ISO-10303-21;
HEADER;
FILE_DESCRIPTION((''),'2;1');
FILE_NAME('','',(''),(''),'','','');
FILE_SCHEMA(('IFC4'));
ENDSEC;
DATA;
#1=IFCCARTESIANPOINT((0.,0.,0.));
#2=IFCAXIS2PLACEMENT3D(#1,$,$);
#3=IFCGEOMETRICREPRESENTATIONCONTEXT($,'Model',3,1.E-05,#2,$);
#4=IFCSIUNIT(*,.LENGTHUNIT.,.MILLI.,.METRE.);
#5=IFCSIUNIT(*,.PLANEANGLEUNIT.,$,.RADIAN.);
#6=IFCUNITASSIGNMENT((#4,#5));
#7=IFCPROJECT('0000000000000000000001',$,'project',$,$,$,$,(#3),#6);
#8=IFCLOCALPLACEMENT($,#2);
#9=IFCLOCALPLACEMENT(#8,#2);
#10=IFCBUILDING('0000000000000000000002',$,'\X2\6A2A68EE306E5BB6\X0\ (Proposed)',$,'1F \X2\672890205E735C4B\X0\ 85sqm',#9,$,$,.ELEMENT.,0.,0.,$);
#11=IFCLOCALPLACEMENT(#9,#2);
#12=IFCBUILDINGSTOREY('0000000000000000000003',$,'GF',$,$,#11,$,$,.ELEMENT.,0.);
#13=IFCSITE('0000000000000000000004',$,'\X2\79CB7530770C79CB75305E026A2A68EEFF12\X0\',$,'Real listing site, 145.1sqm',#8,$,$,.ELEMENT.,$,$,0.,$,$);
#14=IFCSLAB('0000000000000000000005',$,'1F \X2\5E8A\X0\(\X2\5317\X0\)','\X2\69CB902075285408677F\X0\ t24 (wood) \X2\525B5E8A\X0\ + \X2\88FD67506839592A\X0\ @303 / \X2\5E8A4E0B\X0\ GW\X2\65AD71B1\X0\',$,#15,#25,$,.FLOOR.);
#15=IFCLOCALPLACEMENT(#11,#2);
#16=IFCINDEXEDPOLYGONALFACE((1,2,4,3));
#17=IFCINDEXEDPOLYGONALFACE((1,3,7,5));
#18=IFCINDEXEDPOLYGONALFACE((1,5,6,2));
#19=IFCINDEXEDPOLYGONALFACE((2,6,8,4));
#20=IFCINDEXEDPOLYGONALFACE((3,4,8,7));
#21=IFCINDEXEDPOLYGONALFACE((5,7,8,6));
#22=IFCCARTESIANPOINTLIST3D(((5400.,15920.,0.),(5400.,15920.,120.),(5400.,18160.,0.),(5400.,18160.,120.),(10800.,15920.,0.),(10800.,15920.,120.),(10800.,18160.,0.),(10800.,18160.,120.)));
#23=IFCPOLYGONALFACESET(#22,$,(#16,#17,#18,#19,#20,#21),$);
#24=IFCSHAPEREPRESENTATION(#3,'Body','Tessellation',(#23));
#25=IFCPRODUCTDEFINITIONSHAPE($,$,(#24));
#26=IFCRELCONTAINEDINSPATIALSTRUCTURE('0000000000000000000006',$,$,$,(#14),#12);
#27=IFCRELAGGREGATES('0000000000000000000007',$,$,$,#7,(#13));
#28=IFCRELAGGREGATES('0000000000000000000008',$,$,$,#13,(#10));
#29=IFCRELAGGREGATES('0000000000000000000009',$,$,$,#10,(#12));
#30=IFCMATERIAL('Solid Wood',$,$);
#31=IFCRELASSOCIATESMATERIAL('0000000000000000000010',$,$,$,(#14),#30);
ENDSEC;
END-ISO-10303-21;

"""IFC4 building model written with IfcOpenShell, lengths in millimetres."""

from ifc_helpers import new_model, si_unit, frame, frame_2d, origin, place, context, project, spatial, rectangle, extrude, material, element, save


model = new_model("IFC4")

# Units and contexts
model_context = context("Model", 3, precision=1e-05, world=origin())
ifc_project = project(units=[si_unit("LENGTHUNIT", "METRE", prefix="MILLI"), si_unit("PLANEANGLEUNIT", "RADIAN")], contexts=[model_context])

# Site, building, storey
site_placement = place(None, origin())
site = spatial("IfcSite", under=ifc_project, at=site_placement, Name="秋田県秋田市横森２", ObjectType="Real listing site, 145.1sqm", CompositionType="ELEMENT", RefElevation=0.0)
building_placement = place(site_placement, origin())
building = spatial("IfcBuilding", under=site, at=building_placement, Name="横森の家 (Proposed)", ObjectType="1F 木造平屋 85sqm", CompositionType="ELEMENT", ElevationOfRefHeight=0.0, ElevationOfTerrain=0.0)
storey_placement = place(building_placement, origin())
storey = spatial("IfcBuildingStorey", under=building, at=storey_placement, Name="GF", CompositionType="ELEMENT", Elevation=0.0)

# Slab
ifc_material_1 = material(Name="Solid Wood")
slab_1_placement = place(storey_placement, frame((2700.0, 7960.0, 0.0)))
element("IfcSlab", 1, at=slab_1_placement, inside=storey, material=ifc_material_1, Name="1F 床(北)", Description="構造用合板 t24 (wood) 剛床 + 製材根太 @303 / 床下 GW断熱", PredefinedType="FLOOR", context=model_context, shape_type="SweptSolid", body=[
    extrude(rectangle(XDim=5400.0, YDim=2240.0, at=frame_2d((2700.0, 1120.0))), frame((2700.0, 7960.0, 0.0)), (0.0, 0.0, 1.0), 120.0),
])

save(model, "model.ifc")
